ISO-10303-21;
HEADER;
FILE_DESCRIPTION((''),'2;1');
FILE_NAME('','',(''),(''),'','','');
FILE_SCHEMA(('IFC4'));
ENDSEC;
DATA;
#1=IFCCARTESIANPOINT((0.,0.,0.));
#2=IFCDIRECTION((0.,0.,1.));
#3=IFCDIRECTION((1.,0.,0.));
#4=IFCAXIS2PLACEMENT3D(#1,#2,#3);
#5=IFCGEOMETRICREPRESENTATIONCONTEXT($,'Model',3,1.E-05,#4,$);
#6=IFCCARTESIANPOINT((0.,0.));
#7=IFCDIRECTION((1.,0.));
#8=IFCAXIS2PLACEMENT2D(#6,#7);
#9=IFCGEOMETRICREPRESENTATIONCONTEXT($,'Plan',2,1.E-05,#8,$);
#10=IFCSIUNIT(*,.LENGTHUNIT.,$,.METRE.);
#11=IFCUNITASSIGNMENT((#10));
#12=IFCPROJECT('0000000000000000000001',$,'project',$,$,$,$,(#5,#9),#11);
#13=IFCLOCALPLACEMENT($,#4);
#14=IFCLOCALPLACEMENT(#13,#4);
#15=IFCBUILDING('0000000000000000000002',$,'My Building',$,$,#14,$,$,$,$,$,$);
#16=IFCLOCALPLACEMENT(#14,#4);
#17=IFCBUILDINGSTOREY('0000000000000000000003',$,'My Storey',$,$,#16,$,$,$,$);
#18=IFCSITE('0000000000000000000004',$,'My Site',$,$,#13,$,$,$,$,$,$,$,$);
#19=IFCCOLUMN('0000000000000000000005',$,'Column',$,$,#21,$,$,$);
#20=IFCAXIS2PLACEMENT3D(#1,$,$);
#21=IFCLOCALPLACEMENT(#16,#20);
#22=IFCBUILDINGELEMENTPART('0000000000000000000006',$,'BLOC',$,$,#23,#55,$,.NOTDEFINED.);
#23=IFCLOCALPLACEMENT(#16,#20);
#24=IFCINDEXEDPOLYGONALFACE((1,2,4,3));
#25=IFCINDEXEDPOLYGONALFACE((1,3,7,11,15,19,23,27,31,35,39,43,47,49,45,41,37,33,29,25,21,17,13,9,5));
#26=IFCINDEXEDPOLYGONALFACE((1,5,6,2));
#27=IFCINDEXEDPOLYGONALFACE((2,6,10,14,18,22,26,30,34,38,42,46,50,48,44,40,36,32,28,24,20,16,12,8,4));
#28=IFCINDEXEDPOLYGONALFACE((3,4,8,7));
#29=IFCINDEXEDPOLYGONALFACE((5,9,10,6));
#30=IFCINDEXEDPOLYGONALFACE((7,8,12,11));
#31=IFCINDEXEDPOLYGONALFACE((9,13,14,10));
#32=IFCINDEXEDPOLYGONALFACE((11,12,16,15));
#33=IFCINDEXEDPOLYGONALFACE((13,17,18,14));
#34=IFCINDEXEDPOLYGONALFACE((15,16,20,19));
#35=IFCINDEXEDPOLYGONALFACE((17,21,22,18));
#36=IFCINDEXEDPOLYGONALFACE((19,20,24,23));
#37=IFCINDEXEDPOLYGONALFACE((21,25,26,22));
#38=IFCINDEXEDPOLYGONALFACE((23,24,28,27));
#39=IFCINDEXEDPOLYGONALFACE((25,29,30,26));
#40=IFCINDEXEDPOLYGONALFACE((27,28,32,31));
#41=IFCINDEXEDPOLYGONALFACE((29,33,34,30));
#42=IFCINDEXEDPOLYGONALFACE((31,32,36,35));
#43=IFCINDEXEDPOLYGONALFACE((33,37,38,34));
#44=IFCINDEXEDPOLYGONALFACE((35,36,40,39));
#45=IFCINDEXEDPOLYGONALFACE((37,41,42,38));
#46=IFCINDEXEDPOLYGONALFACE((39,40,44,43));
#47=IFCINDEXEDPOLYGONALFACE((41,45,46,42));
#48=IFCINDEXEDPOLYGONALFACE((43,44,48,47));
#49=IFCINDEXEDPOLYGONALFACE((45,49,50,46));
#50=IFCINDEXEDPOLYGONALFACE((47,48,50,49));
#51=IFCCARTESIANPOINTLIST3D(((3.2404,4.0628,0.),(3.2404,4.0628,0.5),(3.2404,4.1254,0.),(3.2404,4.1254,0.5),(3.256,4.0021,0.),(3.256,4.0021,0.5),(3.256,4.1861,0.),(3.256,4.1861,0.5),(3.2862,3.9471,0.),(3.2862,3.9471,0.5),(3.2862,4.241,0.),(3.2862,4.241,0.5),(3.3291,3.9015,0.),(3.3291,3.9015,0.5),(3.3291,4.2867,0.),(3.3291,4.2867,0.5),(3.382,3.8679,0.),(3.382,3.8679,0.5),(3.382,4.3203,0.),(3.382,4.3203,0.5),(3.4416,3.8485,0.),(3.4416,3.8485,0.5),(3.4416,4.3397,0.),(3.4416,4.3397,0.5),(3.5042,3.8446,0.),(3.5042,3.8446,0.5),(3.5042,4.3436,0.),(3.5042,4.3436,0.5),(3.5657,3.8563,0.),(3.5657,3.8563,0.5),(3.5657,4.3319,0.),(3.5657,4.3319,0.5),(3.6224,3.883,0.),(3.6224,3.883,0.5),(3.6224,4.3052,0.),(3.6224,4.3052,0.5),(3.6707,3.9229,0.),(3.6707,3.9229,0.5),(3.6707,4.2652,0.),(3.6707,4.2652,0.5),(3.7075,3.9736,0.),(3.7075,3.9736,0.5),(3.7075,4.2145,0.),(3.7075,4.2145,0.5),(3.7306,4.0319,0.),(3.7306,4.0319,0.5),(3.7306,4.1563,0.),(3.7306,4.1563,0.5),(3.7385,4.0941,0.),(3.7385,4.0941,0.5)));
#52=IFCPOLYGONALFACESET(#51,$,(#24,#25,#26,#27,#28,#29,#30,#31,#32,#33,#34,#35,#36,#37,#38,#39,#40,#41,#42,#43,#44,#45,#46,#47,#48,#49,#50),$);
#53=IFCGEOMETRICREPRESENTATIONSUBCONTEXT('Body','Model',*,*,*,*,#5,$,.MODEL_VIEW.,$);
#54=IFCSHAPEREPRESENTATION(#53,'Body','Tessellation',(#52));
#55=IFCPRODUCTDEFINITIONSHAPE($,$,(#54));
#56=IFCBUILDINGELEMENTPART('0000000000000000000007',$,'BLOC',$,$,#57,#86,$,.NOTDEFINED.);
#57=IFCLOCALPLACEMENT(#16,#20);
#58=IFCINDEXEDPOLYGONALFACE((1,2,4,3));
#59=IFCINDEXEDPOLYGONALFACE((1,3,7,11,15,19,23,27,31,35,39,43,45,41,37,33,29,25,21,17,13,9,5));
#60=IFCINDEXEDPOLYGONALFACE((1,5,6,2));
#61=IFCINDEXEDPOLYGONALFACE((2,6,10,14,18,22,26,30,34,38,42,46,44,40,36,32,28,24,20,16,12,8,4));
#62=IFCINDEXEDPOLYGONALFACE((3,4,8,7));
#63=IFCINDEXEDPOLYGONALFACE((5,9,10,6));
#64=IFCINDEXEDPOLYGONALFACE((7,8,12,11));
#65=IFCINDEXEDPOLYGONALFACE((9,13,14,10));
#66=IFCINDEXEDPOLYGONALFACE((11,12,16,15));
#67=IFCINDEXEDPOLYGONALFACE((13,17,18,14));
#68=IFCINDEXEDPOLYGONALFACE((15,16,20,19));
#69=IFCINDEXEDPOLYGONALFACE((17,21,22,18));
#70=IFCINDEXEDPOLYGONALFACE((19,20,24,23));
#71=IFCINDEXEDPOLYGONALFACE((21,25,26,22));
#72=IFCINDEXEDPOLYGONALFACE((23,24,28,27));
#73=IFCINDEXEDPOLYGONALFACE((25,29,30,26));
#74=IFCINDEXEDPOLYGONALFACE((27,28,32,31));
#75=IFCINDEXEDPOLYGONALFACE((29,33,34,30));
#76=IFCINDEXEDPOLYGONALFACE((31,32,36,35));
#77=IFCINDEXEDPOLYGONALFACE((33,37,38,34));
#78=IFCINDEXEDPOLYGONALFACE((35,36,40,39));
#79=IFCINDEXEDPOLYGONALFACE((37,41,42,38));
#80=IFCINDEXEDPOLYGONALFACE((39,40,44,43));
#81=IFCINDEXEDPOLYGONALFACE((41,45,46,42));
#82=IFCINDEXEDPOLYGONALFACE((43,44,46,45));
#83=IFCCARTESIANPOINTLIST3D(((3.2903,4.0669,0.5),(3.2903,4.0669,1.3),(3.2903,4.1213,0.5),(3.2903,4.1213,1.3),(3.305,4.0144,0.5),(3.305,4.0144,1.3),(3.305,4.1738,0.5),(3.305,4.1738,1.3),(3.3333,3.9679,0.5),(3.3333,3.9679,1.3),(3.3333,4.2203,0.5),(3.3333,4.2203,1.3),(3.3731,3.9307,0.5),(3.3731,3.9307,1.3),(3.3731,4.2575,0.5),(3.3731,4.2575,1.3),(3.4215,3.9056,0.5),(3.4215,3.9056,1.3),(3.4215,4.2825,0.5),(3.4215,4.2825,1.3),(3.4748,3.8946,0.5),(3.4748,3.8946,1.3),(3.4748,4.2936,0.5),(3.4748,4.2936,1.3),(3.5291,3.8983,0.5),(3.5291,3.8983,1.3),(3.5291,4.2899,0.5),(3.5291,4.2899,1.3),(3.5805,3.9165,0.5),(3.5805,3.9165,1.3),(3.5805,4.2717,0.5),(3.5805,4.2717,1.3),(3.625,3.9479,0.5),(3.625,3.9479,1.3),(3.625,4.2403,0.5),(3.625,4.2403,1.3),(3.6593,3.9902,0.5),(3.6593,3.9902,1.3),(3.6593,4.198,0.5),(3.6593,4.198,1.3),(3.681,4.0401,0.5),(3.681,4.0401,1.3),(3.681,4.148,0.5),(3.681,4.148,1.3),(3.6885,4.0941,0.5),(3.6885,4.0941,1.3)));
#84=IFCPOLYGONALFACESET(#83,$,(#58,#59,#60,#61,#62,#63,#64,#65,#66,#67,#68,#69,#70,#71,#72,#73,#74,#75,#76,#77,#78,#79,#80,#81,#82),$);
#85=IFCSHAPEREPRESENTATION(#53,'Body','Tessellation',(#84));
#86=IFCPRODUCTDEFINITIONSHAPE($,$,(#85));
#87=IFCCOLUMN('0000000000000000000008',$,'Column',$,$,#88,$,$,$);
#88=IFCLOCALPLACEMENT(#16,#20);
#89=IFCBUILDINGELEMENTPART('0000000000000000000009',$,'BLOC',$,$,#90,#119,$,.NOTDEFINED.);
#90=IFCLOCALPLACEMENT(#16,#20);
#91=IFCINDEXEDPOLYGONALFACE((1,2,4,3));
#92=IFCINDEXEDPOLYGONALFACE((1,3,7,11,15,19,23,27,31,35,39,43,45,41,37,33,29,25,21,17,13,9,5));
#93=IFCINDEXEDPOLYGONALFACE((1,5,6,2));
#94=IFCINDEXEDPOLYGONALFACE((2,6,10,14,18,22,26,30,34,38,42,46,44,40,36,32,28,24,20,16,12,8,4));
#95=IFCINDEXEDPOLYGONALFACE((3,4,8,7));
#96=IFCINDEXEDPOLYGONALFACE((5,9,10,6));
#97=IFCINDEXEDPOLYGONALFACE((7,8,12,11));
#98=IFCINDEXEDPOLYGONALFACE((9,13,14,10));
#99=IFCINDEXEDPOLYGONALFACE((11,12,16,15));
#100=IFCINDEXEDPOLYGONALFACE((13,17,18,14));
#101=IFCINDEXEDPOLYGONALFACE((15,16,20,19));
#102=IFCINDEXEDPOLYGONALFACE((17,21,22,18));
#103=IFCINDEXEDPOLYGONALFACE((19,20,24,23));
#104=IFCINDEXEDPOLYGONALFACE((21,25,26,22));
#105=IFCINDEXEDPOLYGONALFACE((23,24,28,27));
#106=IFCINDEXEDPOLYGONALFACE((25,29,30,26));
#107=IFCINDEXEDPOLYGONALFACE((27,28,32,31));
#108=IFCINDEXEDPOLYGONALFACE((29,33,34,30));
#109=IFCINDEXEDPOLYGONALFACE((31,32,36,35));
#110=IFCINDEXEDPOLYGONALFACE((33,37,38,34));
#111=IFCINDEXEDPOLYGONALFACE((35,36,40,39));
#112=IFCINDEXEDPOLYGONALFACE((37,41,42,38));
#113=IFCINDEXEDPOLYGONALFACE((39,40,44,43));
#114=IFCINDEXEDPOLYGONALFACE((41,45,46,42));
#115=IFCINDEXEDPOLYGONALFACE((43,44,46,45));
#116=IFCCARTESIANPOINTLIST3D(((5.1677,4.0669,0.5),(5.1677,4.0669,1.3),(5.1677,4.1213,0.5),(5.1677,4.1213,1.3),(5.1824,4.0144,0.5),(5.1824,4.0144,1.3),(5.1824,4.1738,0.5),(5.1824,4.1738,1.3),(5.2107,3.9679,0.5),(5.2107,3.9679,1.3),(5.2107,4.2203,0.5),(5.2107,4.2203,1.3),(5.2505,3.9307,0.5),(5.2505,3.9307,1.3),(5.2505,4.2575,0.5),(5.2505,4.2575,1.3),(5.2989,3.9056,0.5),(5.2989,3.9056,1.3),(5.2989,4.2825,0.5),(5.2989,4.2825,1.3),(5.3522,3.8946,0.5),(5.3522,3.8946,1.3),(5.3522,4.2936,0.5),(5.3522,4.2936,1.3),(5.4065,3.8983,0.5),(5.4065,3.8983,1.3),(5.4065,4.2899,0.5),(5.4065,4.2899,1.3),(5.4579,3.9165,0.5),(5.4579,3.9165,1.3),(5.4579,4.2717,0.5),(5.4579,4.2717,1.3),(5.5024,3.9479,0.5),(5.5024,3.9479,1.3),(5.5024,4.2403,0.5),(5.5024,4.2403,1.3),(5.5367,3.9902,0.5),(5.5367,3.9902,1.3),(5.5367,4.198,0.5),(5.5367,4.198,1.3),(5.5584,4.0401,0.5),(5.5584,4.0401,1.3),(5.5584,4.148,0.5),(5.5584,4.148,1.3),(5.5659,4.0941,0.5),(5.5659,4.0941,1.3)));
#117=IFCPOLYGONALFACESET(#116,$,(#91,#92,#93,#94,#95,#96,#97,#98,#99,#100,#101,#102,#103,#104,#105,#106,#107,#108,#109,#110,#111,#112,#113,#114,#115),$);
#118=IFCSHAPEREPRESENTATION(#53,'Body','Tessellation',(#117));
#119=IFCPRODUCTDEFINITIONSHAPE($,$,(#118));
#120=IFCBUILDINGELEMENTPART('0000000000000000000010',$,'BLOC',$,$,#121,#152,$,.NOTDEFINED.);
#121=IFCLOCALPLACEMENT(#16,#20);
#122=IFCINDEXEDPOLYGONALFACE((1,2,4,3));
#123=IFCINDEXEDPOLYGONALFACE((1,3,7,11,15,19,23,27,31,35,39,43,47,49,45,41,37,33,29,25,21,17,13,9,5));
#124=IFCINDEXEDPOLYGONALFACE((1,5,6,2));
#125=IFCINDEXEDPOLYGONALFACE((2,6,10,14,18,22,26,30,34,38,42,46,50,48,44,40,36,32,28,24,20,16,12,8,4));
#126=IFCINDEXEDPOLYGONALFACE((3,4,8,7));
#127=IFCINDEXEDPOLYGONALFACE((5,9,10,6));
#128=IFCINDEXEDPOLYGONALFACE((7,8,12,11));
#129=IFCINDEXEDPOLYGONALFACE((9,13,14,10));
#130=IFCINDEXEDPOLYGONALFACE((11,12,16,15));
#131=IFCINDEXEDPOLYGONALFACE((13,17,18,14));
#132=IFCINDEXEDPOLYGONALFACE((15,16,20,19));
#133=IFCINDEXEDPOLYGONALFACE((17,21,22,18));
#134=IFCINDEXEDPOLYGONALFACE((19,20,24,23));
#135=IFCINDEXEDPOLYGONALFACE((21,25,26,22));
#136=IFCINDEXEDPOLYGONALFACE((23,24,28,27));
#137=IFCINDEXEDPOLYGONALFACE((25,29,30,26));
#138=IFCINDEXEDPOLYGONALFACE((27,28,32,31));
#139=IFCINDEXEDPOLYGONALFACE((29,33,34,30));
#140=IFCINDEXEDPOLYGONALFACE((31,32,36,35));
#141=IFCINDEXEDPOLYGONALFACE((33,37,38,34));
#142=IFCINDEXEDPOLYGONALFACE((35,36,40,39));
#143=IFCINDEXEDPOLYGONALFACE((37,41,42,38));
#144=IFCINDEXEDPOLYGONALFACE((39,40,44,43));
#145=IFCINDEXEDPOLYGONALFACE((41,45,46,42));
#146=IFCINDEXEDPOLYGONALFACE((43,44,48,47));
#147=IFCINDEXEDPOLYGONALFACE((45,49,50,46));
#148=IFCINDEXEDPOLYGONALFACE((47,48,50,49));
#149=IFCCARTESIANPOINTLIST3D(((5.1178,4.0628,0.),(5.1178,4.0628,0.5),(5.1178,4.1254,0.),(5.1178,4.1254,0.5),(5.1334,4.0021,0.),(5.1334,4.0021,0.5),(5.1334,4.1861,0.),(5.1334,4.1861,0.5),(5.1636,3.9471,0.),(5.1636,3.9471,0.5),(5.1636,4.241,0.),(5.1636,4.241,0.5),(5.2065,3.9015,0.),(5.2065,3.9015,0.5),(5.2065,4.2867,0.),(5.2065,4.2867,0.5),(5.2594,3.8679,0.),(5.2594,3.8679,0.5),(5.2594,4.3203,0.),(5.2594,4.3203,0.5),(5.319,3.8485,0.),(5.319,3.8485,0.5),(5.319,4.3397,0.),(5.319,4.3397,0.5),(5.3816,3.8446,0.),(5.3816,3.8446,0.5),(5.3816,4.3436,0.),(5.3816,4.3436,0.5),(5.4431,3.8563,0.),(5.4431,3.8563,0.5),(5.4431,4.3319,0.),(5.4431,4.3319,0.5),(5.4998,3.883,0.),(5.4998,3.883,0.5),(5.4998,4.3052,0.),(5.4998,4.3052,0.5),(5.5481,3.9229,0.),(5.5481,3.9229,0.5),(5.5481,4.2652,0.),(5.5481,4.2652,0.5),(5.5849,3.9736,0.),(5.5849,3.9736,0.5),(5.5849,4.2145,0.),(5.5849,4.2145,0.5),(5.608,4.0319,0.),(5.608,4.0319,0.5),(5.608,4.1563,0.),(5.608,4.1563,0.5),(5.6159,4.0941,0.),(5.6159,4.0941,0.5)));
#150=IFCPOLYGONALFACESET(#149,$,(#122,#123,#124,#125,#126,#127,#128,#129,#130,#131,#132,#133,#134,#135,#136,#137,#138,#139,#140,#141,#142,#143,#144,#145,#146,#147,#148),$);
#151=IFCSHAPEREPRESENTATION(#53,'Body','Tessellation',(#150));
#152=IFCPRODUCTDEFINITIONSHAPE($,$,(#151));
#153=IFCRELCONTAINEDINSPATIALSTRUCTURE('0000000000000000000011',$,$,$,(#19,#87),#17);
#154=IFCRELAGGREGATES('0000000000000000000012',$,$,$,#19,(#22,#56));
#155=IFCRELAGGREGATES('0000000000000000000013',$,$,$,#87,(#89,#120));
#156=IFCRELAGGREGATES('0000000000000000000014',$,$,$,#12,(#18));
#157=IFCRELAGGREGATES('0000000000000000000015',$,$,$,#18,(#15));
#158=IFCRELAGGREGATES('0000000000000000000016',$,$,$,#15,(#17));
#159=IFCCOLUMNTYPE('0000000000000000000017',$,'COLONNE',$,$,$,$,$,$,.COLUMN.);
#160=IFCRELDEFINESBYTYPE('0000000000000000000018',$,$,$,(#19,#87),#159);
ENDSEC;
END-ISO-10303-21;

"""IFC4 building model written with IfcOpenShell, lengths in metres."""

from ifc_helpers import new_model, si_unit, frame, origin_with_axes, origin_2d, origin_2d_with_axis, place, context, subcontext, project, spatial, circle_curve, outline, extrude, type_object, element, aggregate, save


model = new_model("IFC4")

# Units and contexts
model_context = context("Model", 3, precision=1e-05, world=origin_with_axes())
plan_context = context("Plan", 2, precision=1e-05, world=origin_2d_with_axis())
body_context = subcontext(model_context, "Body", "Model", "MODEL_VIEW")
ifc_project = project(units=[si_unit("LENGTHUNIT", "METRE")], contexts=[model_context, plan_context])

# Site, building, storey
site_placement = place(None, origin_with_axes())
site = spatial("IfcSite", under=ifc_project, at=site_placement, Name="My Site")
building_placement = place(site_placement, origin_with_axes())
building = spatial("IfcBuilding", under=site, at=building_placement, Name="My Building")
storey_placement = place(building_placement, origin_with_axes())
storey = spatial("IfcBuildingStorey", under=building, at=storey_placement, Name="My Storey")

# Columns, building element parts
column_type = type_object("IfcColumnType", Name="COLONNE", PredefinedType="COLUMN")
column_1_placement = place(storey_placement, frame((3.4885, 4.0941, 0.0), z_axis=(0.0, 0.0, 1.0), x_axis=(1.0, 0.0, 0.0)))
column_1 = element("IfcColumn", 1, at=column_1_placement, inside=storey, type_object=column_type, Name="Column")
building_element_part_1_placement = place(None, frame((3.4885, 4.0941, 0.0), z_axis=(0.0, 0.0, 1.0), x_axis=(1.0, 0.0, 0.0)))
building_element_part_1 = element("IfcBuildingElementPart", 2, at=building_element_part_1_placement, Name="BLOC", PredefinedType="NOTDEFINED", context=body_context, shape_type="SweptSolid", body=[
    extrude(outline(circle_curve(origin_2d(), 0.25)), origin_with_axes(), (0.0, 0.0, 1.0), 0.5),
])
building_element_part_2_placement = place(None, frame((3.4885, 4.0941, 0.5), z_axis=(0.0, 0.0, 1.0), x_axis=(1.0, 0.0, 0.0)))
building_element_part_2 = element("IfcBuildingElementPart", 3, at=building_element_part_2_placement, Name="BLOC", PredefinedType="NOTDEFINED", context=body_context, shape_type="SweptSolid", body=[
    extrude(outline(circle_curve(origin_2d(), 0.2)), None, (0.0, 0.0, 1.0), 0.8),
])
aggregate(column_1, [building_element_part_1, building_element_part_2])
column_2_placement = place(storey_placement, frame((5.3659, 4.0941, 0.0), z_axis=(0.0, 0.0, 1.0), x_axis=(1.0, 0.0, 0.0)))
column_2 = element("IfcColumn", 4, at=column_2_placement, inside=storey, type_object=column_type, Name="Column")
building_element_part_3_placement = place(column_2_placement, frame((0.0, 0.0, 0.5), z_axis=(0.0, 0.0, 1.0), x_axis=(1.0, 0.0, 0.0)))
building_element_part_3 = element("IfcBuildingElementPart", 5, at=building_element_part_3_placement, Name="BLOC", PredefinedType="NOTDEFINED", context=body_context, shape_type="SweptSolid", body=[
    extrude(outline(circle_curve(origin_2d(), 0.2)), None, (0.0, 0.0, 1.0), 0.8),
])
building_element_part_4_placement = place(column_2_placement, origin_with_axes())
building_element_part_4 = element("IfcBuildingElementPart", 6, at=building_element_part_4_placement, Name="BLOC", PredefinedType="NOTDEFINED", context=body_context, shape_type="SweptSolid", body=[
    extrude(outline(circle_curve(origin_2d(), 0.25)), origin_with_axes(), (0.0, 0.0, 1.0), 0.5),
])
aggregate(column_2, [building_element_part_3, building_element_part_4])

save(model, "model.ifc")
